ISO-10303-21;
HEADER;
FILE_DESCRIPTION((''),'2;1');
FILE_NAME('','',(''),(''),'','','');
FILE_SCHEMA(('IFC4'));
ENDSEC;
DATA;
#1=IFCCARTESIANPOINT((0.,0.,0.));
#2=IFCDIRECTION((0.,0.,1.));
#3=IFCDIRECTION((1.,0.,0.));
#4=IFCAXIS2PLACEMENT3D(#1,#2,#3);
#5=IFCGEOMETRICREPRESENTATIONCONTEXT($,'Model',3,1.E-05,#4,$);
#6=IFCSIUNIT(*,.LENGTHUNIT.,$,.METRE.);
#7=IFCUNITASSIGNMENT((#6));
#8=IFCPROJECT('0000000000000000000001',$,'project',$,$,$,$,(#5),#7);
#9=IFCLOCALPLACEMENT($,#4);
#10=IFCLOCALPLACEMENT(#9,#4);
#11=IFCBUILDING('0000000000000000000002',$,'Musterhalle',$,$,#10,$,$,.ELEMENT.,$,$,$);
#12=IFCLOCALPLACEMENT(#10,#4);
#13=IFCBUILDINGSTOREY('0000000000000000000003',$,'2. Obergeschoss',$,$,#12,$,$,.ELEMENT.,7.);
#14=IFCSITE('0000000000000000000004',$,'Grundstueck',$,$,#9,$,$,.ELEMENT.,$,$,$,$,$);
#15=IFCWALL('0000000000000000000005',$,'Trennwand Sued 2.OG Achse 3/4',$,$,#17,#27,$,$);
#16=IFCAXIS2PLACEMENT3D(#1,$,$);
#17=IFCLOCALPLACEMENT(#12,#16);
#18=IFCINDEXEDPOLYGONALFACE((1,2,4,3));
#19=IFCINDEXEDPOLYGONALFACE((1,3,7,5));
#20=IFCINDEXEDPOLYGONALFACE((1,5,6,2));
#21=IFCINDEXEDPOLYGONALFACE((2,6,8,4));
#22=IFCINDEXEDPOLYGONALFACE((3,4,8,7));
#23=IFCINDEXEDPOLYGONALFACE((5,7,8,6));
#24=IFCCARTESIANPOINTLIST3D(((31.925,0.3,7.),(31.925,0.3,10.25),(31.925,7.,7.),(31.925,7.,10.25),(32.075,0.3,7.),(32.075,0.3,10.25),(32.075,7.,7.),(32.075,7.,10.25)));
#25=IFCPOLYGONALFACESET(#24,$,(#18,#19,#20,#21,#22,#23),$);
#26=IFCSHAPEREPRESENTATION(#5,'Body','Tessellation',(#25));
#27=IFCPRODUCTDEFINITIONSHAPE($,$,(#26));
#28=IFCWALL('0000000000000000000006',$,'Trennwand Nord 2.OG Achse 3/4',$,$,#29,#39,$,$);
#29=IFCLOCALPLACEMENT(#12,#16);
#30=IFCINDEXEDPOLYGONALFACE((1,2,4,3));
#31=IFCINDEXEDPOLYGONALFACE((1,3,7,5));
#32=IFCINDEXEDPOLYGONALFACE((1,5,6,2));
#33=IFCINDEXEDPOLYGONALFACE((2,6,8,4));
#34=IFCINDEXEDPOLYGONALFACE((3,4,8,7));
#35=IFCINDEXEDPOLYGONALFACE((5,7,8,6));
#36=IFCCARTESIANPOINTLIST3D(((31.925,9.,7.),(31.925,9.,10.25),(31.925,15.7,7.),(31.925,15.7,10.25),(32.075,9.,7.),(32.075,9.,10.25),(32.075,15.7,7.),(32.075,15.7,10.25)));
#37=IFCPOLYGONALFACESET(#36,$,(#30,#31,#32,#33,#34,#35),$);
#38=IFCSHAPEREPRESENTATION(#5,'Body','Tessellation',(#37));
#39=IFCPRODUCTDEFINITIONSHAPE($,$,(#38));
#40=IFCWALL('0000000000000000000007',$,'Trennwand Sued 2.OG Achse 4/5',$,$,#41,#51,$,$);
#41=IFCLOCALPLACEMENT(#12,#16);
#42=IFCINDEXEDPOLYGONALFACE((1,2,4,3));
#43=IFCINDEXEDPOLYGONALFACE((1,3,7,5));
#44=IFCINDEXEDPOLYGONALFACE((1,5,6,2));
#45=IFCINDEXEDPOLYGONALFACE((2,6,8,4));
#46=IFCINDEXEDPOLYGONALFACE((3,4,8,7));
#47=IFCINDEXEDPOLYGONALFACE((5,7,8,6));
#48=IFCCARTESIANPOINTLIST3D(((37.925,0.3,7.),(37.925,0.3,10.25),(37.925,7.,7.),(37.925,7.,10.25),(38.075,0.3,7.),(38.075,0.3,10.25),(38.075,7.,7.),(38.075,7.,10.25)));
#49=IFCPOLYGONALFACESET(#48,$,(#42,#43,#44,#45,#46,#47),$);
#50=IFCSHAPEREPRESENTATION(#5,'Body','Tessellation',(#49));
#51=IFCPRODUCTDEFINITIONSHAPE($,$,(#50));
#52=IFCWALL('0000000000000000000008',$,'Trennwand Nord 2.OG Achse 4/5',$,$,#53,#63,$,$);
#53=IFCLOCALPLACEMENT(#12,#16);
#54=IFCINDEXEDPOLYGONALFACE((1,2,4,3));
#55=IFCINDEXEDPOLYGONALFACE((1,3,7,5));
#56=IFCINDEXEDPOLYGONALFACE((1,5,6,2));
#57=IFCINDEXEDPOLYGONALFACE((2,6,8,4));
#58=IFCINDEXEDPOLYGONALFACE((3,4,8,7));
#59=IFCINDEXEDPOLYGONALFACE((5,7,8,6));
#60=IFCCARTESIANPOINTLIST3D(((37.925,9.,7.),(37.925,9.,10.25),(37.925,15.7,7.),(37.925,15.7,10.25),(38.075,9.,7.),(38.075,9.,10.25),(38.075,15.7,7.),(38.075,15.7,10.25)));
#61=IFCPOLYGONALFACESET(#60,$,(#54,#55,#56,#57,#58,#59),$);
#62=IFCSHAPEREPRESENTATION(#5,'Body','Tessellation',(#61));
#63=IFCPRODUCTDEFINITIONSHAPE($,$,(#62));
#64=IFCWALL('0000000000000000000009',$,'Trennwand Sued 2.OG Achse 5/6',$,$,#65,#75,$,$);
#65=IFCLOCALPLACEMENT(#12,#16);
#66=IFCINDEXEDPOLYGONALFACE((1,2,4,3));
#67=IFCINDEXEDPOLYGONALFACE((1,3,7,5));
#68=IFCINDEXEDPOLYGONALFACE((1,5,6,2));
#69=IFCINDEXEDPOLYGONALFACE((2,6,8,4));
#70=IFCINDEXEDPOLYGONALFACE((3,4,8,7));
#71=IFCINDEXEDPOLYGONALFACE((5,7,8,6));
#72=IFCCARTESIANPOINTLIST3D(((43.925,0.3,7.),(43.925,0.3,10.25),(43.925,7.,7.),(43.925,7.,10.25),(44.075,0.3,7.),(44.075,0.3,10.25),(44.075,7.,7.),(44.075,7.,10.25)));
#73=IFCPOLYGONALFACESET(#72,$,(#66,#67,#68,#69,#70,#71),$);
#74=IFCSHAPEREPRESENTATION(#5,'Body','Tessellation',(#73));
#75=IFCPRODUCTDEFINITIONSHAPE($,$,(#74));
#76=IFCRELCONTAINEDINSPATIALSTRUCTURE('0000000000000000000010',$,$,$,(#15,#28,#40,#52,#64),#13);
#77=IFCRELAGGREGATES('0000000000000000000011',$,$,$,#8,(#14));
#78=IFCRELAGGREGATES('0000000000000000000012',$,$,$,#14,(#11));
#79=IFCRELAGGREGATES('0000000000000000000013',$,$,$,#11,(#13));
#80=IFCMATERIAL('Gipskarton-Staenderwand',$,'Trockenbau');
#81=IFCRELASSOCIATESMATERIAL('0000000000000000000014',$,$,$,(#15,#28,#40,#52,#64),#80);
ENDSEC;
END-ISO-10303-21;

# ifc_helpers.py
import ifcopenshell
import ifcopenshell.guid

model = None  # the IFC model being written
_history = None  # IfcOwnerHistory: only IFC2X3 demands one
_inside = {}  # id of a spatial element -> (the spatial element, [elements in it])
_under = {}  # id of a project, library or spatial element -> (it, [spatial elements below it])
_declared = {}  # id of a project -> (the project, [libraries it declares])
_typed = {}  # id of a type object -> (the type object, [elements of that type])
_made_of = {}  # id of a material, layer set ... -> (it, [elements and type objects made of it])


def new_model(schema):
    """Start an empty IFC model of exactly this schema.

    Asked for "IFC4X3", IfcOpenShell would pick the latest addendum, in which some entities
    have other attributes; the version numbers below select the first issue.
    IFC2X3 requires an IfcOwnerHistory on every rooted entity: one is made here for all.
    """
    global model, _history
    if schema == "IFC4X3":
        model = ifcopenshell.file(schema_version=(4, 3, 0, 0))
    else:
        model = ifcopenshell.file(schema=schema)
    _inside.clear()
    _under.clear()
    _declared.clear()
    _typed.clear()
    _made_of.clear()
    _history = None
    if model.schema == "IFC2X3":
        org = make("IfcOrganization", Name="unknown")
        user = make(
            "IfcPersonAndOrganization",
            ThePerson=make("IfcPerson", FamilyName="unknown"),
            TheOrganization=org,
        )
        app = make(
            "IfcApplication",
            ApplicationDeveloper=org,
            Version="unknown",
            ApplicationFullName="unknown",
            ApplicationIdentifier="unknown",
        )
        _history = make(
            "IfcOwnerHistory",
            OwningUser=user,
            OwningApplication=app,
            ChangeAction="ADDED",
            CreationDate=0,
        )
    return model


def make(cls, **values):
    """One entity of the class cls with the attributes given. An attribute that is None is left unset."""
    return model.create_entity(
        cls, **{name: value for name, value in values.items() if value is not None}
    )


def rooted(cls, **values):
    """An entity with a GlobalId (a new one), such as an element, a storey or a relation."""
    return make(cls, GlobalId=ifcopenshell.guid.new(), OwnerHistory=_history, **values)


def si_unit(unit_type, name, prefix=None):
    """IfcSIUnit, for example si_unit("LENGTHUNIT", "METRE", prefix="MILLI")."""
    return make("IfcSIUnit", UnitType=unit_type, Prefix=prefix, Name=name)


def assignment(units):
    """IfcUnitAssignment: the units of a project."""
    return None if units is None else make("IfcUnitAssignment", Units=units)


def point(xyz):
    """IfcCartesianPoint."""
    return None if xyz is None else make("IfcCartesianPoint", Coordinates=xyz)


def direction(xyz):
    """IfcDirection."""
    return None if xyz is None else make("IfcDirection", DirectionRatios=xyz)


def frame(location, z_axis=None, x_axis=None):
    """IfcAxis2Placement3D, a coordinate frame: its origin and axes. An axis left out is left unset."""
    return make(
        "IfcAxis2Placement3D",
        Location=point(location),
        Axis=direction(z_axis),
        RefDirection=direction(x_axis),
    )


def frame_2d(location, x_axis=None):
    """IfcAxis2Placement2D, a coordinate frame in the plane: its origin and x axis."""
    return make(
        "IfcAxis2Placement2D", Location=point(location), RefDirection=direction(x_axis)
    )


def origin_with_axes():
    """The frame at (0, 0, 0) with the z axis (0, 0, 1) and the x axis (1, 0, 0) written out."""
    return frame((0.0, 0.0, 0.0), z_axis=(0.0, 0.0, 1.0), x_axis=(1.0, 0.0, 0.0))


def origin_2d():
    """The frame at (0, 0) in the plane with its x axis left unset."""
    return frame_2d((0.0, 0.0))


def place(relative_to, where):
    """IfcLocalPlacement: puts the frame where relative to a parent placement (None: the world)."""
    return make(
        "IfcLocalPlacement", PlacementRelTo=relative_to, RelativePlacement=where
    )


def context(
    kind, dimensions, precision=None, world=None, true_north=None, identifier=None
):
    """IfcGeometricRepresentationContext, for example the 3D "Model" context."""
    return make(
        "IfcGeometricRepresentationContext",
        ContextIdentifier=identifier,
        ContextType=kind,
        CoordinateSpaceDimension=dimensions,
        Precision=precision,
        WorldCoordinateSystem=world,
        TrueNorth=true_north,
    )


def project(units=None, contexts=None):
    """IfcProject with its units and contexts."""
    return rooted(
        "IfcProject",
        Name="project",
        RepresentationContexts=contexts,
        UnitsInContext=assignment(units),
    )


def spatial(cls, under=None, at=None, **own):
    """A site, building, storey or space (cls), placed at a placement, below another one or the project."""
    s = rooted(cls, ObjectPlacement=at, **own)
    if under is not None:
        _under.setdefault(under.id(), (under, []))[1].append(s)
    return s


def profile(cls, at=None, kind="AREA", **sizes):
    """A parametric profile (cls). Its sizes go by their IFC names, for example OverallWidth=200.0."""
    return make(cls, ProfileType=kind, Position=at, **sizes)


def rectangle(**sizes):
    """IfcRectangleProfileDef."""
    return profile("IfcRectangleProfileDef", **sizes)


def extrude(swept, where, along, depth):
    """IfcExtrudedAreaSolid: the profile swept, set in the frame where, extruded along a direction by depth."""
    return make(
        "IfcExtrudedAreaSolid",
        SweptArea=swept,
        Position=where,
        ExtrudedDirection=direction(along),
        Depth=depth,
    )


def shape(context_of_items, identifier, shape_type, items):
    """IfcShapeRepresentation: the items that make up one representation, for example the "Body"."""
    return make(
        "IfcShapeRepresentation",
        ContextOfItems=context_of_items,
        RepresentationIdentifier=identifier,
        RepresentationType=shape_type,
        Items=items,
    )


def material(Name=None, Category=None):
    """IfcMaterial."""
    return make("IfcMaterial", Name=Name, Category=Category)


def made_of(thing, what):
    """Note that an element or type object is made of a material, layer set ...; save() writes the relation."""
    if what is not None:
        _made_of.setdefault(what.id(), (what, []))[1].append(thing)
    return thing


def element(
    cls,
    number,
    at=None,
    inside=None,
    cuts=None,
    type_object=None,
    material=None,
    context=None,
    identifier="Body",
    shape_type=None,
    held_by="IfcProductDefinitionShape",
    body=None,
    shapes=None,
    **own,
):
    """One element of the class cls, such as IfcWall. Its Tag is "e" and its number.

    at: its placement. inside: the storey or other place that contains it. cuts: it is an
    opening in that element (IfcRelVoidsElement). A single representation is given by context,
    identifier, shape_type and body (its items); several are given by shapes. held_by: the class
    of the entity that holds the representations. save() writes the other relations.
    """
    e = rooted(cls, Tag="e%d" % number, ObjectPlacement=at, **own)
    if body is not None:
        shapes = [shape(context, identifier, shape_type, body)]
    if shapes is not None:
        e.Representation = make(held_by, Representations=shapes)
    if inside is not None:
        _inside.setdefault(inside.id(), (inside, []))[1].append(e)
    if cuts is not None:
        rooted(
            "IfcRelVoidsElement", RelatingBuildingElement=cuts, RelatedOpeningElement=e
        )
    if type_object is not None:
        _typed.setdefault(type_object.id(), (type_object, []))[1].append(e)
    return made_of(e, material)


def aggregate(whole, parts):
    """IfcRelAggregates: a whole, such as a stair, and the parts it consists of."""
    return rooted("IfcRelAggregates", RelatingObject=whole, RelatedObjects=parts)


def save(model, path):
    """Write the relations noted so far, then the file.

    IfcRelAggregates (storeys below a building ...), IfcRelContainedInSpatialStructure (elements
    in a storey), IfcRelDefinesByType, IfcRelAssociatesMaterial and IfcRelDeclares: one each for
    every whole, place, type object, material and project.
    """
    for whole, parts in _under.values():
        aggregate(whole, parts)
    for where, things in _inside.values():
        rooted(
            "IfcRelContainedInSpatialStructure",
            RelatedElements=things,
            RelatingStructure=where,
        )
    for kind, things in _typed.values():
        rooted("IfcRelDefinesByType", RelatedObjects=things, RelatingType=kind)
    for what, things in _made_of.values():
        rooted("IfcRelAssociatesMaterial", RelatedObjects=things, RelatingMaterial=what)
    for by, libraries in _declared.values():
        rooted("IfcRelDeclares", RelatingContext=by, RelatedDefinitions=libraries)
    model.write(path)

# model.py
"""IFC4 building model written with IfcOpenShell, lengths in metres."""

from ifc_helpers import new_model, si_unit, frame, origin_with_axes, origin_2d, place, context, project, spatial, rectangle, extrude, material, element, save


model = new_model("IFC4")

# Units and contexts
model_context = context("Model", 3, precision=1e-05, world=origin_with_axes())
ifc_project = project(units=[si_unit("LENGTHUNIT", "METRE")], contexts=[model_context])

# Site, building, storey
site_placement = place(None, origin_with_axes())
site = spatial("IfcSite", under=ifc_project, at=site_placement, Name="Grundstueck", CompositionType="ELEMENT")
building_placement = place(site_placement, origin_with_axes())
building = spatial("IfcBuilding", under=site, at=building_placement, Name="Musterhalle", CompositionType="ELEMENT")
storey_placement = place(building_placement, origin_with_axes())
storey = spatial("IfcBuildingStorey", under=building, at=storey_placement, Name="2. Obergeschoss", CompositionType="ELEMENT", Elevation=7.0)

# Walls
placement = place(storey_placement, origin_with_axes())
ifc_material_1 = material(Name="Gipskarton-Staenderwand", Category="Trockenbau")
element("IfcWall", 1, at=placement, inside=storey, material=ifc_material_1, Name="Trennwand Sued 2.OG Achse 3/4", context=model_context, shape_type="SweptSolid", body=[
    extrude(rectangle(XDim=0.15, YDim=6.7, at=origin_2d()), frame((32.0, 3.65, 7.0), z_axis=(0.0, 0.0, 1.0), x_axis=(1.0, 0.0, 0.0)), (0.0, 0.0, 1.0), 3.25),
])
element("IfcWall", 2, at=placement, inside=storey, material=ifc_material_1, Name="Trennwand Nord 2.OG Achse 3/4", context=model_context, shape_type="SweptSolid", body=[
    extrude(rectangle(XDim=0.15, YDim=6.7, at=origin_2d()), frame((32.0, 12.35, 7.0), z_axis=(0.0, 0.0, 1.0), x_axis=(1.0, 0.0, 0.0)), (0.0, 0.0, 1.0), 3.25),
])
element("IfcWall", 3, at=placement, inside=storey, material=ifc_material_1, Name="Trennwand Sued 2.OG Achse 4/5", context=model_context, shape_type="SweptSolid", body=[
    extrude(rectangle(XDim=0.15, YDim=6.7, at=origin_2d()), frame((38.0, 3.65, 7.0), z_axis=(0.0, 0.0, 1.0), x_axis=(1.0, 0.0, 0.0)), (0.0, 0.0, 1.0), 3.25),
])
element("IfcWall", 4, at=placement, inside=storey, material=ifc_material_1, Name="Trennwand Nord 2.OG Achse 4/5", context=model_context, shape_type="SweptSolid", body=[
    extrude(rectangle(XDim=0.15, YDim=6.7, at=origin_2d()), frame((38.0, 12.35, 7.0), z_axis=(0.0, 0.0, 1.0), x_axis=(1.0, 0.0, 0.0)), (0.0, 0.0, 1.0), 3.25),
])
element("IfcWall", 5, at=placement, inside=storey, material=ifc_material_1, Name="Trennwand Sued 2.OG Achse 5/6", context=model_context, shape_type="SweptSolid", body=[
    extrude(rectangle(XDim=0.15, YDim=6.7, at=origin_2d()), frame((44.0, 3.65, 7.0), z_axis=(0.0, 0.0, 1.0), x_axis=(1.0, 0.0, 0.0)), (0.0, 0.0, 1.0), 3.25),
])

save(model, "model.ifc")
